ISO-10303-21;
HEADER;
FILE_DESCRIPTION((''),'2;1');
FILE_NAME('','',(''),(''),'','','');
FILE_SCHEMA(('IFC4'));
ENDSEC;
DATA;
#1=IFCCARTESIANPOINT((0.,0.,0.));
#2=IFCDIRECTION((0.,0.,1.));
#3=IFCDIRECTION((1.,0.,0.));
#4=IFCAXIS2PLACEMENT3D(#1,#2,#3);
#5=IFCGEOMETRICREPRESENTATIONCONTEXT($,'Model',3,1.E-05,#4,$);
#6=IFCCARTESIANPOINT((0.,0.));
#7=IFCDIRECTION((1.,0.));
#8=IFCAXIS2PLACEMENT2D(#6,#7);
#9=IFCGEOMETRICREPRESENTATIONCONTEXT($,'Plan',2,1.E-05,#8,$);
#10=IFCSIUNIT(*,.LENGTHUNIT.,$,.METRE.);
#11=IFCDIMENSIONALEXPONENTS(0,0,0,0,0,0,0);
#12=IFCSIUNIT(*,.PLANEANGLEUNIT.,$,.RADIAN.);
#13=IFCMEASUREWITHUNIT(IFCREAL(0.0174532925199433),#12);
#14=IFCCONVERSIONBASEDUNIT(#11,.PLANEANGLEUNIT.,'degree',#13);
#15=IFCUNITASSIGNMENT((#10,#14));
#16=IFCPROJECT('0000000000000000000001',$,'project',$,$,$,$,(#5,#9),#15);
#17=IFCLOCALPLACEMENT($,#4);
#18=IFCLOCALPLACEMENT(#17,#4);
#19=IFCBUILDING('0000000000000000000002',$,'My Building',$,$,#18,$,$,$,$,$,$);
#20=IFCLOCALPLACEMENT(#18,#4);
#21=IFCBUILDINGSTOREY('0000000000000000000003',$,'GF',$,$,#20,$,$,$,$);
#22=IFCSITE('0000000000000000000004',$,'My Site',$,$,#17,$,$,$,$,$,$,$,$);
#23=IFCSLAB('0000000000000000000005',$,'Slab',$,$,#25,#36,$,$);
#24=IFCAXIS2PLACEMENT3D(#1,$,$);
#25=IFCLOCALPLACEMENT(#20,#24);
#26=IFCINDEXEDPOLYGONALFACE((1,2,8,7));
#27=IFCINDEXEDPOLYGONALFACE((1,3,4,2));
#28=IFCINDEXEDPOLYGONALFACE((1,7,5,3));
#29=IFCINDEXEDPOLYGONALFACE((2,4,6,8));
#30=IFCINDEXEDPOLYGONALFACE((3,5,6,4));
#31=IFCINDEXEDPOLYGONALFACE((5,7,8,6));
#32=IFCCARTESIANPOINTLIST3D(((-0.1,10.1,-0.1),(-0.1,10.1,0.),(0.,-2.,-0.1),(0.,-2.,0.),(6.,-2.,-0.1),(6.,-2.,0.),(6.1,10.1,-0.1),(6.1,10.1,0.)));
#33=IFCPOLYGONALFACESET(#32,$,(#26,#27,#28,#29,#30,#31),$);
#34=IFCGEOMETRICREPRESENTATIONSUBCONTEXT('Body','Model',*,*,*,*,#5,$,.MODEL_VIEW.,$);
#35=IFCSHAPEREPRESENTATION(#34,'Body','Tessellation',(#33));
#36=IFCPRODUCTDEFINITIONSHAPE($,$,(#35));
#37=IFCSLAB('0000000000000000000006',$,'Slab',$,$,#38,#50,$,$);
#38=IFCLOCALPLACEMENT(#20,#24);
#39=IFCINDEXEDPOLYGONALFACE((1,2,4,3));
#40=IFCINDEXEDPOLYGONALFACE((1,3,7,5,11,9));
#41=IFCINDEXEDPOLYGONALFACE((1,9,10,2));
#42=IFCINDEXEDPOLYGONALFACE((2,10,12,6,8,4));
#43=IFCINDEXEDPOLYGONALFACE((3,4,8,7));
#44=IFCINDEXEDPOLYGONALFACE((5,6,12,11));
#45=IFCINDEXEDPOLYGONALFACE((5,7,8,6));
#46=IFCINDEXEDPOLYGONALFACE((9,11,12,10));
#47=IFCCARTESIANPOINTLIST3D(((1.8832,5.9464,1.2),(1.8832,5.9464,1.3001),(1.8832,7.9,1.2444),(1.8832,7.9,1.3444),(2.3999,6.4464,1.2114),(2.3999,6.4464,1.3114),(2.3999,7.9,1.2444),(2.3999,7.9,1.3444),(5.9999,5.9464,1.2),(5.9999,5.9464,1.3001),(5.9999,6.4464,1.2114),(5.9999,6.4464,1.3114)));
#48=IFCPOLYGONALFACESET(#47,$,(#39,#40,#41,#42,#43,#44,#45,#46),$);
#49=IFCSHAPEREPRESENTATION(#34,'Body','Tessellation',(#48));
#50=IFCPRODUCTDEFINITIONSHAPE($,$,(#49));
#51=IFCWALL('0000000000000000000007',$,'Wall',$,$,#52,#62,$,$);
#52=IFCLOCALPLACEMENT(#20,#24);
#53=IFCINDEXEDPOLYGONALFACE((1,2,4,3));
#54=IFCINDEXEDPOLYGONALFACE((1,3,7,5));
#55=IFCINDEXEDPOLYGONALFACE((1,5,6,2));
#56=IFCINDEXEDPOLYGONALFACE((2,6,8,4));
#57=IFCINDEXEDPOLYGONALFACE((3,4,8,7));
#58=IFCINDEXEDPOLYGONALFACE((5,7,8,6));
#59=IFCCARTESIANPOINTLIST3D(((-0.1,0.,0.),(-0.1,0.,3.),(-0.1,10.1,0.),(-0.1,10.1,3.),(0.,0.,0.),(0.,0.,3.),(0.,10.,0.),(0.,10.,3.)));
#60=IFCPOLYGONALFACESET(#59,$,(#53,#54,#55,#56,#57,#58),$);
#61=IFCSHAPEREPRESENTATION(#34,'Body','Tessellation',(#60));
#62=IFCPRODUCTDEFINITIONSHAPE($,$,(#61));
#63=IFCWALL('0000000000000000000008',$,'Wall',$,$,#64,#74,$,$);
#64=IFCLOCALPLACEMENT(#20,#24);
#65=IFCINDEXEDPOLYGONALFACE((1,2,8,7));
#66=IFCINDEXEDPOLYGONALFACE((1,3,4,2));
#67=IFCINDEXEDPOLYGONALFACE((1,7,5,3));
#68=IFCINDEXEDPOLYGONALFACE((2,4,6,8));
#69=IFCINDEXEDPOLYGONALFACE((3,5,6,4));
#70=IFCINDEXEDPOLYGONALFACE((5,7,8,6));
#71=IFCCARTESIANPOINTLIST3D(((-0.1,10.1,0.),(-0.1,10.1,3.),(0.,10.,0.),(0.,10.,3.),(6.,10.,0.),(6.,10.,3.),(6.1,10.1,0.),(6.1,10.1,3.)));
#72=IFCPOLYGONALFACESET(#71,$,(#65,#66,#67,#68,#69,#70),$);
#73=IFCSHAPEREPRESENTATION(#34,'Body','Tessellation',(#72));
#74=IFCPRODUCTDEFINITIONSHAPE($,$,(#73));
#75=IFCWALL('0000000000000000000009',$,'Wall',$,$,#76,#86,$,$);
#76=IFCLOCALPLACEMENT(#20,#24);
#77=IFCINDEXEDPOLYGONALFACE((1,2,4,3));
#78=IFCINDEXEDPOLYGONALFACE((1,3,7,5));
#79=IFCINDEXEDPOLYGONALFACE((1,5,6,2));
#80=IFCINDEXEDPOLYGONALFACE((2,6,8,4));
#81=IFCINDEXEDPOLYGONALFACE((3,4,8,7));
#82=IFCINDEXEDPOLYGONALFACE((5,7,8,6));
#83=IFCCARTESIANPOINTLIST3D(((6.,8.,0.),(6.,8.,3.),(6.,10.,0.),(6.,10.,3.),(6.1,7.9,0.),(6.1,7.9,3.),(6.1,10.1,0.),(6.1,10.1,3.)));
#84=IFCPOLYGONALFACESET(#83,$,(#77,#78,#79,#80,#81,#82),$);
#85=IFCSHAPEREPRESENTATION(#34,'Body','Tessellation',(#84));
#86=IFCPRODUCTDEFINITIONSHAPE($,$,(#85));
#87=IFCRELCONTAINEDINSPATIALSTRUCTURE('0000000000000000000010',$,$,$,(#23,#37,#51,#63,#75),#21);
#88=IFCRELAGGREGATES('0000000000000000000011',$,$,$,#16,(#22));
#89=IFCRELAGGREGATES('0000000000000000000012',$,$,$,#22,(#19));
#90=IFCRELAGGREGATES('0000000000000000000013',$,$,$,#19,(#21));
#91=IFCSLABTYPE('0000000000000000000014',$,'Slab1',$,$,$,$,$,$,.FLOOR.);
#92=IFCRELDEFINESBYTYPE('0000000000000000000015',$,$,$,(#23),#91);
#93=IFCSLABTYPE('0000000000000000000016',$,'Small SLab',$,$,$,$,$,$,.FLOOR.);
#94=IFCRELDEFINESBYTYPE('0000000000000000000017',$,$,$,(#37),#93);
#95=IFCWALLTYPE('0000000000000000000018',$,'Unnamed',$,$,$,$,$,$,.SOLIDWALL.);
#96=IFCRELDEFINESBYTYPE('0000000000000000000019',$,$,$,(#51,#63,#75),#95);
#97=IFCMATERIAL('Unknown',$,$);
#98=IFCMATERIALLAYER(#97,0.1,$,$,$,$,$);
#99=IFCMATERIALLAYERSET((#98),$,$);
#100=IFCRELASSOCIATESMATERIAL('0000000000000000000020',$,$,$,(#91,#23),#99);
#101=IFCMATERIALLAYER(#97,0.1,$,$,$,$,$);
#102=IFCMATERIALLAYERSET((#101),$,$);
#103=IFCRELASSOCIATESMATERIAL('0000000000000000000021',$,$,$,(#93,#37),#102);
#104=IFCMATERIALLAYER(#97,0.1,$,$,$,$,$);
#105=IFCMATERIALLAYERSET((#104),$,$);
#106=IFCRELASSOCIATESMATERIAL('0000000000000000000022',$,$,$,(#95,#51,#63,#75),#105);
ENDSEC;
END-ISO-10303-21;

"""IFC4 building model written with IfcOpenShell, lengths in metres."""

from ifc_helpers import new_model, entity, si_unit, converted_unit, frame, origin_with_axes, origin_2d_with_axis, place, context, subcontext, project, spatial, line, indexed_curve, outline, extrude, material, layer, layer_set, layer_usage, type_object, element, save


model = new_model("IFC4")

# Units and contexts
model_context = context("Model", 3, precision=1e-05, world=origin_with_axes())
plan_context = context("Plan", 2, precision=1e-05, world=origin_2d_with_axis())
body_context_1 = subcontext(model_context, "Body", "Model", "MODEL_VIEW")
ifc_project = project(units=[si_unit("LENGTHUNIT", "METRE"), converted_unit("PLANEANGLEUNIT", "degree", entity("IfcReal", 0.0174532925199433), si_unit("PLANEANGLEUNIT", "RADIAN"), dimensions=[0, 0, 0, 0, 0, 0, 0])], contexts=[model_context, plan_context])

# Site, building, storey
site_placement = place(None, origin_with_axes())
site = spatial("IfcSite", under=ifc_project, at=site_placement, Name="My Site")
building_placement = place(site_placement, origin_with_axes())
building = spatial("IfcBuilding", under=site, at=building_placement, Name="My Building")
storey_placement = place(building_placement, origin_with_axes())
storey = spatial("IfcBuildingStorey", under=building, at=storey_placement, Name="GF")

# Slabs
ifc_material = material(Name="Unknown")
ifc_layer_1 = layer(ifc_material, 0.1)
ifc_layer_set_1 = layer_set([ifc_layer_1])
ifc_layer_usage_1 = layer_usage(ifc_layer_set_1, "AXIS3", "POSITIVE", -0.1)
slab_type_1 = type_object("IfcSlabType", Name="Slab1", PredefinedType="FLOOR", material=ifc_layer_set_1)
slab_1_placement = place(storey_placement, frame((-0.1, 10.1, 0.0), z_axis=(0.0, 0.0, 1.0), x_axis=(1.0, 0.0, 0.0)))
element("IfcSlab", 1, at=slab_1_placement, inside=storey, type_object=slab_type_1, material=ifc_layer_usage_1, Name="Slab", context=body_context_1, shape_type="SweptSolid", body=[
    extrude(outline(indexed_curve([(0.0, 0.0), (6.2, 0.0), (6.1, -12.1), (0.1, -12.1), (0.0, 0.0)])), frame((0.0, 0.0, -0.1), z_axis=(0.0, 0.0, 1.0), x_axis=(1.0, 0.0, 0.0)), (0.0, 0.0, 1.0), 0.1),
])
ifc_layer_2 = layer(ifc_material, 0.1)
ifc_layer_set_2 = layer_set([ifc_layer_2])
ifc_layer_usage_2 = layer_usage(ifc_layer_set_2, "AXIS3", "POSITIVE", -0.1)
slab_type_2 = type_object("IfcSlabType", Name="Small SLab", PredefinedType="FLOOR", material=ifc_layer_set_2)
slab_2_placement = place(storey_placement, frame((1.8832, 5.9464, 1.3001), z_axis=(0.0, -0.022687, 0.999743), x_axis=(1.0, 0.0, 0.0)))
element("IfcSlab", 2, at=slab_2_placement, inside=storey, type_object=slab_type_2, material=ifc_layer_usage_2, Name="Slab", context=body_context_1, shape_type="SweptSolid", body=[
    extrude(outline(indexed_curve([(0.0, 0.0), (4.1168, 0.0), (4.1168, 0.5001), (0.5168, 0.5001), (0.5168, 1.9541), (0.0, 1.9541), (0.0, 0.0)])), frame((0.0, -0.0023, -0.1), z_axis=(0.0, 0.0, 1.0), x_axis=(1.0, 0.0, 0.0)), (0.0, 0.022687, 0.999743), 0.1),
])

# Walls
ifc_layer_3 = layer(ifc_material, 0.1)
ifc_layer_set_3 = layer_set([ifc_layer_3])
ifc_layer_usage_3 = layer_usage(ifc_layer_set_3, "AXIS2", "POSITIVE", 0.0)
wall_type_1 = type_object("IfcWallType", Name="Unnamed", PredefinedType="SOLIDWALL", material=ifc_layer_set_3)
wall_1_placement = place(storey_placement, frame((0.0, 0.0, 0.0), z_axis=(0.0, 0.0, 1.0), x_axis=(0.0, 1.0, 0.0)))
element("IfcWall", 3, at=wall_1_placement, inside=storey, type_object=wall_type_1, material=ifc_layer_usage_3, Name="Wall", context=body_context_1, shape_type="SweptSolid", body=[
    extrude(outline(indexed_curve([(0.0, 0.0), (0.0, 0.1), (10.1, 0.1), (10.0, 0.0)], segments=[line(1, 2, 3, 4, 1)])), origin_with_axes(), (0.0, 0.0, 1.0), 3.0),
])
ifc_layer_usage_4 = layer_usage(ifc_layer_set_3, "AXIS2", "POSITIVE", 0.0)
wall_2_placement = place(storey_placement, frame((0.0, 10.0, 0.0), z_axis=(0.0, 0.0, 1.0), x_axis=(1.0, 0.0, 0.0)))
element("IfcWall", 4, at=wall_2_placement, inside=storey, type_object=wall_type_1, material=ifc_layer_usage_4, Name="Wall", context=body_context_1, shape_type="SweptSolid", body=[
    extrude(outline(indexed_curve([(0.0, 0.0), (-0.1, 0.1), (6.1, 0.1), (6.0, 0.0)], segments=[line(1, 2, 3, 4, 1)])), origin_with_axes(), (0.0, 0.0, 1.0), 3.0),
])
ifc_layer_usage_5 = layer_usage(ifc_layer_set_3, "AXIS2", "POSITIVE", 0.0)
wall_3_placement = place(storey_placement, frame((6.0, 10.0, 0.0), z_axis=(0.0, 0.0, 1.0), x_axis=(0.0, -1.0, 0.0)))
element("IfcWall", 5, at=wall_3_placement, inside=storey, type_object=wall_type_1, material=ifc_layer_usage_5, Name="Wall", context=body_context_1, shape_type="SweptSolid", body=[
    extrude(outline(indexed_curve([(0.0, 0.0), (-0.1, 0.1), (2.1, 0.1), (2.0, 0.0)], segments=[line(1, 2, 3, 4, 1)])), origin_with_axes(), (0.0, 0.0, 1.0), 3.0),
])

save(model, "model.ifc")
